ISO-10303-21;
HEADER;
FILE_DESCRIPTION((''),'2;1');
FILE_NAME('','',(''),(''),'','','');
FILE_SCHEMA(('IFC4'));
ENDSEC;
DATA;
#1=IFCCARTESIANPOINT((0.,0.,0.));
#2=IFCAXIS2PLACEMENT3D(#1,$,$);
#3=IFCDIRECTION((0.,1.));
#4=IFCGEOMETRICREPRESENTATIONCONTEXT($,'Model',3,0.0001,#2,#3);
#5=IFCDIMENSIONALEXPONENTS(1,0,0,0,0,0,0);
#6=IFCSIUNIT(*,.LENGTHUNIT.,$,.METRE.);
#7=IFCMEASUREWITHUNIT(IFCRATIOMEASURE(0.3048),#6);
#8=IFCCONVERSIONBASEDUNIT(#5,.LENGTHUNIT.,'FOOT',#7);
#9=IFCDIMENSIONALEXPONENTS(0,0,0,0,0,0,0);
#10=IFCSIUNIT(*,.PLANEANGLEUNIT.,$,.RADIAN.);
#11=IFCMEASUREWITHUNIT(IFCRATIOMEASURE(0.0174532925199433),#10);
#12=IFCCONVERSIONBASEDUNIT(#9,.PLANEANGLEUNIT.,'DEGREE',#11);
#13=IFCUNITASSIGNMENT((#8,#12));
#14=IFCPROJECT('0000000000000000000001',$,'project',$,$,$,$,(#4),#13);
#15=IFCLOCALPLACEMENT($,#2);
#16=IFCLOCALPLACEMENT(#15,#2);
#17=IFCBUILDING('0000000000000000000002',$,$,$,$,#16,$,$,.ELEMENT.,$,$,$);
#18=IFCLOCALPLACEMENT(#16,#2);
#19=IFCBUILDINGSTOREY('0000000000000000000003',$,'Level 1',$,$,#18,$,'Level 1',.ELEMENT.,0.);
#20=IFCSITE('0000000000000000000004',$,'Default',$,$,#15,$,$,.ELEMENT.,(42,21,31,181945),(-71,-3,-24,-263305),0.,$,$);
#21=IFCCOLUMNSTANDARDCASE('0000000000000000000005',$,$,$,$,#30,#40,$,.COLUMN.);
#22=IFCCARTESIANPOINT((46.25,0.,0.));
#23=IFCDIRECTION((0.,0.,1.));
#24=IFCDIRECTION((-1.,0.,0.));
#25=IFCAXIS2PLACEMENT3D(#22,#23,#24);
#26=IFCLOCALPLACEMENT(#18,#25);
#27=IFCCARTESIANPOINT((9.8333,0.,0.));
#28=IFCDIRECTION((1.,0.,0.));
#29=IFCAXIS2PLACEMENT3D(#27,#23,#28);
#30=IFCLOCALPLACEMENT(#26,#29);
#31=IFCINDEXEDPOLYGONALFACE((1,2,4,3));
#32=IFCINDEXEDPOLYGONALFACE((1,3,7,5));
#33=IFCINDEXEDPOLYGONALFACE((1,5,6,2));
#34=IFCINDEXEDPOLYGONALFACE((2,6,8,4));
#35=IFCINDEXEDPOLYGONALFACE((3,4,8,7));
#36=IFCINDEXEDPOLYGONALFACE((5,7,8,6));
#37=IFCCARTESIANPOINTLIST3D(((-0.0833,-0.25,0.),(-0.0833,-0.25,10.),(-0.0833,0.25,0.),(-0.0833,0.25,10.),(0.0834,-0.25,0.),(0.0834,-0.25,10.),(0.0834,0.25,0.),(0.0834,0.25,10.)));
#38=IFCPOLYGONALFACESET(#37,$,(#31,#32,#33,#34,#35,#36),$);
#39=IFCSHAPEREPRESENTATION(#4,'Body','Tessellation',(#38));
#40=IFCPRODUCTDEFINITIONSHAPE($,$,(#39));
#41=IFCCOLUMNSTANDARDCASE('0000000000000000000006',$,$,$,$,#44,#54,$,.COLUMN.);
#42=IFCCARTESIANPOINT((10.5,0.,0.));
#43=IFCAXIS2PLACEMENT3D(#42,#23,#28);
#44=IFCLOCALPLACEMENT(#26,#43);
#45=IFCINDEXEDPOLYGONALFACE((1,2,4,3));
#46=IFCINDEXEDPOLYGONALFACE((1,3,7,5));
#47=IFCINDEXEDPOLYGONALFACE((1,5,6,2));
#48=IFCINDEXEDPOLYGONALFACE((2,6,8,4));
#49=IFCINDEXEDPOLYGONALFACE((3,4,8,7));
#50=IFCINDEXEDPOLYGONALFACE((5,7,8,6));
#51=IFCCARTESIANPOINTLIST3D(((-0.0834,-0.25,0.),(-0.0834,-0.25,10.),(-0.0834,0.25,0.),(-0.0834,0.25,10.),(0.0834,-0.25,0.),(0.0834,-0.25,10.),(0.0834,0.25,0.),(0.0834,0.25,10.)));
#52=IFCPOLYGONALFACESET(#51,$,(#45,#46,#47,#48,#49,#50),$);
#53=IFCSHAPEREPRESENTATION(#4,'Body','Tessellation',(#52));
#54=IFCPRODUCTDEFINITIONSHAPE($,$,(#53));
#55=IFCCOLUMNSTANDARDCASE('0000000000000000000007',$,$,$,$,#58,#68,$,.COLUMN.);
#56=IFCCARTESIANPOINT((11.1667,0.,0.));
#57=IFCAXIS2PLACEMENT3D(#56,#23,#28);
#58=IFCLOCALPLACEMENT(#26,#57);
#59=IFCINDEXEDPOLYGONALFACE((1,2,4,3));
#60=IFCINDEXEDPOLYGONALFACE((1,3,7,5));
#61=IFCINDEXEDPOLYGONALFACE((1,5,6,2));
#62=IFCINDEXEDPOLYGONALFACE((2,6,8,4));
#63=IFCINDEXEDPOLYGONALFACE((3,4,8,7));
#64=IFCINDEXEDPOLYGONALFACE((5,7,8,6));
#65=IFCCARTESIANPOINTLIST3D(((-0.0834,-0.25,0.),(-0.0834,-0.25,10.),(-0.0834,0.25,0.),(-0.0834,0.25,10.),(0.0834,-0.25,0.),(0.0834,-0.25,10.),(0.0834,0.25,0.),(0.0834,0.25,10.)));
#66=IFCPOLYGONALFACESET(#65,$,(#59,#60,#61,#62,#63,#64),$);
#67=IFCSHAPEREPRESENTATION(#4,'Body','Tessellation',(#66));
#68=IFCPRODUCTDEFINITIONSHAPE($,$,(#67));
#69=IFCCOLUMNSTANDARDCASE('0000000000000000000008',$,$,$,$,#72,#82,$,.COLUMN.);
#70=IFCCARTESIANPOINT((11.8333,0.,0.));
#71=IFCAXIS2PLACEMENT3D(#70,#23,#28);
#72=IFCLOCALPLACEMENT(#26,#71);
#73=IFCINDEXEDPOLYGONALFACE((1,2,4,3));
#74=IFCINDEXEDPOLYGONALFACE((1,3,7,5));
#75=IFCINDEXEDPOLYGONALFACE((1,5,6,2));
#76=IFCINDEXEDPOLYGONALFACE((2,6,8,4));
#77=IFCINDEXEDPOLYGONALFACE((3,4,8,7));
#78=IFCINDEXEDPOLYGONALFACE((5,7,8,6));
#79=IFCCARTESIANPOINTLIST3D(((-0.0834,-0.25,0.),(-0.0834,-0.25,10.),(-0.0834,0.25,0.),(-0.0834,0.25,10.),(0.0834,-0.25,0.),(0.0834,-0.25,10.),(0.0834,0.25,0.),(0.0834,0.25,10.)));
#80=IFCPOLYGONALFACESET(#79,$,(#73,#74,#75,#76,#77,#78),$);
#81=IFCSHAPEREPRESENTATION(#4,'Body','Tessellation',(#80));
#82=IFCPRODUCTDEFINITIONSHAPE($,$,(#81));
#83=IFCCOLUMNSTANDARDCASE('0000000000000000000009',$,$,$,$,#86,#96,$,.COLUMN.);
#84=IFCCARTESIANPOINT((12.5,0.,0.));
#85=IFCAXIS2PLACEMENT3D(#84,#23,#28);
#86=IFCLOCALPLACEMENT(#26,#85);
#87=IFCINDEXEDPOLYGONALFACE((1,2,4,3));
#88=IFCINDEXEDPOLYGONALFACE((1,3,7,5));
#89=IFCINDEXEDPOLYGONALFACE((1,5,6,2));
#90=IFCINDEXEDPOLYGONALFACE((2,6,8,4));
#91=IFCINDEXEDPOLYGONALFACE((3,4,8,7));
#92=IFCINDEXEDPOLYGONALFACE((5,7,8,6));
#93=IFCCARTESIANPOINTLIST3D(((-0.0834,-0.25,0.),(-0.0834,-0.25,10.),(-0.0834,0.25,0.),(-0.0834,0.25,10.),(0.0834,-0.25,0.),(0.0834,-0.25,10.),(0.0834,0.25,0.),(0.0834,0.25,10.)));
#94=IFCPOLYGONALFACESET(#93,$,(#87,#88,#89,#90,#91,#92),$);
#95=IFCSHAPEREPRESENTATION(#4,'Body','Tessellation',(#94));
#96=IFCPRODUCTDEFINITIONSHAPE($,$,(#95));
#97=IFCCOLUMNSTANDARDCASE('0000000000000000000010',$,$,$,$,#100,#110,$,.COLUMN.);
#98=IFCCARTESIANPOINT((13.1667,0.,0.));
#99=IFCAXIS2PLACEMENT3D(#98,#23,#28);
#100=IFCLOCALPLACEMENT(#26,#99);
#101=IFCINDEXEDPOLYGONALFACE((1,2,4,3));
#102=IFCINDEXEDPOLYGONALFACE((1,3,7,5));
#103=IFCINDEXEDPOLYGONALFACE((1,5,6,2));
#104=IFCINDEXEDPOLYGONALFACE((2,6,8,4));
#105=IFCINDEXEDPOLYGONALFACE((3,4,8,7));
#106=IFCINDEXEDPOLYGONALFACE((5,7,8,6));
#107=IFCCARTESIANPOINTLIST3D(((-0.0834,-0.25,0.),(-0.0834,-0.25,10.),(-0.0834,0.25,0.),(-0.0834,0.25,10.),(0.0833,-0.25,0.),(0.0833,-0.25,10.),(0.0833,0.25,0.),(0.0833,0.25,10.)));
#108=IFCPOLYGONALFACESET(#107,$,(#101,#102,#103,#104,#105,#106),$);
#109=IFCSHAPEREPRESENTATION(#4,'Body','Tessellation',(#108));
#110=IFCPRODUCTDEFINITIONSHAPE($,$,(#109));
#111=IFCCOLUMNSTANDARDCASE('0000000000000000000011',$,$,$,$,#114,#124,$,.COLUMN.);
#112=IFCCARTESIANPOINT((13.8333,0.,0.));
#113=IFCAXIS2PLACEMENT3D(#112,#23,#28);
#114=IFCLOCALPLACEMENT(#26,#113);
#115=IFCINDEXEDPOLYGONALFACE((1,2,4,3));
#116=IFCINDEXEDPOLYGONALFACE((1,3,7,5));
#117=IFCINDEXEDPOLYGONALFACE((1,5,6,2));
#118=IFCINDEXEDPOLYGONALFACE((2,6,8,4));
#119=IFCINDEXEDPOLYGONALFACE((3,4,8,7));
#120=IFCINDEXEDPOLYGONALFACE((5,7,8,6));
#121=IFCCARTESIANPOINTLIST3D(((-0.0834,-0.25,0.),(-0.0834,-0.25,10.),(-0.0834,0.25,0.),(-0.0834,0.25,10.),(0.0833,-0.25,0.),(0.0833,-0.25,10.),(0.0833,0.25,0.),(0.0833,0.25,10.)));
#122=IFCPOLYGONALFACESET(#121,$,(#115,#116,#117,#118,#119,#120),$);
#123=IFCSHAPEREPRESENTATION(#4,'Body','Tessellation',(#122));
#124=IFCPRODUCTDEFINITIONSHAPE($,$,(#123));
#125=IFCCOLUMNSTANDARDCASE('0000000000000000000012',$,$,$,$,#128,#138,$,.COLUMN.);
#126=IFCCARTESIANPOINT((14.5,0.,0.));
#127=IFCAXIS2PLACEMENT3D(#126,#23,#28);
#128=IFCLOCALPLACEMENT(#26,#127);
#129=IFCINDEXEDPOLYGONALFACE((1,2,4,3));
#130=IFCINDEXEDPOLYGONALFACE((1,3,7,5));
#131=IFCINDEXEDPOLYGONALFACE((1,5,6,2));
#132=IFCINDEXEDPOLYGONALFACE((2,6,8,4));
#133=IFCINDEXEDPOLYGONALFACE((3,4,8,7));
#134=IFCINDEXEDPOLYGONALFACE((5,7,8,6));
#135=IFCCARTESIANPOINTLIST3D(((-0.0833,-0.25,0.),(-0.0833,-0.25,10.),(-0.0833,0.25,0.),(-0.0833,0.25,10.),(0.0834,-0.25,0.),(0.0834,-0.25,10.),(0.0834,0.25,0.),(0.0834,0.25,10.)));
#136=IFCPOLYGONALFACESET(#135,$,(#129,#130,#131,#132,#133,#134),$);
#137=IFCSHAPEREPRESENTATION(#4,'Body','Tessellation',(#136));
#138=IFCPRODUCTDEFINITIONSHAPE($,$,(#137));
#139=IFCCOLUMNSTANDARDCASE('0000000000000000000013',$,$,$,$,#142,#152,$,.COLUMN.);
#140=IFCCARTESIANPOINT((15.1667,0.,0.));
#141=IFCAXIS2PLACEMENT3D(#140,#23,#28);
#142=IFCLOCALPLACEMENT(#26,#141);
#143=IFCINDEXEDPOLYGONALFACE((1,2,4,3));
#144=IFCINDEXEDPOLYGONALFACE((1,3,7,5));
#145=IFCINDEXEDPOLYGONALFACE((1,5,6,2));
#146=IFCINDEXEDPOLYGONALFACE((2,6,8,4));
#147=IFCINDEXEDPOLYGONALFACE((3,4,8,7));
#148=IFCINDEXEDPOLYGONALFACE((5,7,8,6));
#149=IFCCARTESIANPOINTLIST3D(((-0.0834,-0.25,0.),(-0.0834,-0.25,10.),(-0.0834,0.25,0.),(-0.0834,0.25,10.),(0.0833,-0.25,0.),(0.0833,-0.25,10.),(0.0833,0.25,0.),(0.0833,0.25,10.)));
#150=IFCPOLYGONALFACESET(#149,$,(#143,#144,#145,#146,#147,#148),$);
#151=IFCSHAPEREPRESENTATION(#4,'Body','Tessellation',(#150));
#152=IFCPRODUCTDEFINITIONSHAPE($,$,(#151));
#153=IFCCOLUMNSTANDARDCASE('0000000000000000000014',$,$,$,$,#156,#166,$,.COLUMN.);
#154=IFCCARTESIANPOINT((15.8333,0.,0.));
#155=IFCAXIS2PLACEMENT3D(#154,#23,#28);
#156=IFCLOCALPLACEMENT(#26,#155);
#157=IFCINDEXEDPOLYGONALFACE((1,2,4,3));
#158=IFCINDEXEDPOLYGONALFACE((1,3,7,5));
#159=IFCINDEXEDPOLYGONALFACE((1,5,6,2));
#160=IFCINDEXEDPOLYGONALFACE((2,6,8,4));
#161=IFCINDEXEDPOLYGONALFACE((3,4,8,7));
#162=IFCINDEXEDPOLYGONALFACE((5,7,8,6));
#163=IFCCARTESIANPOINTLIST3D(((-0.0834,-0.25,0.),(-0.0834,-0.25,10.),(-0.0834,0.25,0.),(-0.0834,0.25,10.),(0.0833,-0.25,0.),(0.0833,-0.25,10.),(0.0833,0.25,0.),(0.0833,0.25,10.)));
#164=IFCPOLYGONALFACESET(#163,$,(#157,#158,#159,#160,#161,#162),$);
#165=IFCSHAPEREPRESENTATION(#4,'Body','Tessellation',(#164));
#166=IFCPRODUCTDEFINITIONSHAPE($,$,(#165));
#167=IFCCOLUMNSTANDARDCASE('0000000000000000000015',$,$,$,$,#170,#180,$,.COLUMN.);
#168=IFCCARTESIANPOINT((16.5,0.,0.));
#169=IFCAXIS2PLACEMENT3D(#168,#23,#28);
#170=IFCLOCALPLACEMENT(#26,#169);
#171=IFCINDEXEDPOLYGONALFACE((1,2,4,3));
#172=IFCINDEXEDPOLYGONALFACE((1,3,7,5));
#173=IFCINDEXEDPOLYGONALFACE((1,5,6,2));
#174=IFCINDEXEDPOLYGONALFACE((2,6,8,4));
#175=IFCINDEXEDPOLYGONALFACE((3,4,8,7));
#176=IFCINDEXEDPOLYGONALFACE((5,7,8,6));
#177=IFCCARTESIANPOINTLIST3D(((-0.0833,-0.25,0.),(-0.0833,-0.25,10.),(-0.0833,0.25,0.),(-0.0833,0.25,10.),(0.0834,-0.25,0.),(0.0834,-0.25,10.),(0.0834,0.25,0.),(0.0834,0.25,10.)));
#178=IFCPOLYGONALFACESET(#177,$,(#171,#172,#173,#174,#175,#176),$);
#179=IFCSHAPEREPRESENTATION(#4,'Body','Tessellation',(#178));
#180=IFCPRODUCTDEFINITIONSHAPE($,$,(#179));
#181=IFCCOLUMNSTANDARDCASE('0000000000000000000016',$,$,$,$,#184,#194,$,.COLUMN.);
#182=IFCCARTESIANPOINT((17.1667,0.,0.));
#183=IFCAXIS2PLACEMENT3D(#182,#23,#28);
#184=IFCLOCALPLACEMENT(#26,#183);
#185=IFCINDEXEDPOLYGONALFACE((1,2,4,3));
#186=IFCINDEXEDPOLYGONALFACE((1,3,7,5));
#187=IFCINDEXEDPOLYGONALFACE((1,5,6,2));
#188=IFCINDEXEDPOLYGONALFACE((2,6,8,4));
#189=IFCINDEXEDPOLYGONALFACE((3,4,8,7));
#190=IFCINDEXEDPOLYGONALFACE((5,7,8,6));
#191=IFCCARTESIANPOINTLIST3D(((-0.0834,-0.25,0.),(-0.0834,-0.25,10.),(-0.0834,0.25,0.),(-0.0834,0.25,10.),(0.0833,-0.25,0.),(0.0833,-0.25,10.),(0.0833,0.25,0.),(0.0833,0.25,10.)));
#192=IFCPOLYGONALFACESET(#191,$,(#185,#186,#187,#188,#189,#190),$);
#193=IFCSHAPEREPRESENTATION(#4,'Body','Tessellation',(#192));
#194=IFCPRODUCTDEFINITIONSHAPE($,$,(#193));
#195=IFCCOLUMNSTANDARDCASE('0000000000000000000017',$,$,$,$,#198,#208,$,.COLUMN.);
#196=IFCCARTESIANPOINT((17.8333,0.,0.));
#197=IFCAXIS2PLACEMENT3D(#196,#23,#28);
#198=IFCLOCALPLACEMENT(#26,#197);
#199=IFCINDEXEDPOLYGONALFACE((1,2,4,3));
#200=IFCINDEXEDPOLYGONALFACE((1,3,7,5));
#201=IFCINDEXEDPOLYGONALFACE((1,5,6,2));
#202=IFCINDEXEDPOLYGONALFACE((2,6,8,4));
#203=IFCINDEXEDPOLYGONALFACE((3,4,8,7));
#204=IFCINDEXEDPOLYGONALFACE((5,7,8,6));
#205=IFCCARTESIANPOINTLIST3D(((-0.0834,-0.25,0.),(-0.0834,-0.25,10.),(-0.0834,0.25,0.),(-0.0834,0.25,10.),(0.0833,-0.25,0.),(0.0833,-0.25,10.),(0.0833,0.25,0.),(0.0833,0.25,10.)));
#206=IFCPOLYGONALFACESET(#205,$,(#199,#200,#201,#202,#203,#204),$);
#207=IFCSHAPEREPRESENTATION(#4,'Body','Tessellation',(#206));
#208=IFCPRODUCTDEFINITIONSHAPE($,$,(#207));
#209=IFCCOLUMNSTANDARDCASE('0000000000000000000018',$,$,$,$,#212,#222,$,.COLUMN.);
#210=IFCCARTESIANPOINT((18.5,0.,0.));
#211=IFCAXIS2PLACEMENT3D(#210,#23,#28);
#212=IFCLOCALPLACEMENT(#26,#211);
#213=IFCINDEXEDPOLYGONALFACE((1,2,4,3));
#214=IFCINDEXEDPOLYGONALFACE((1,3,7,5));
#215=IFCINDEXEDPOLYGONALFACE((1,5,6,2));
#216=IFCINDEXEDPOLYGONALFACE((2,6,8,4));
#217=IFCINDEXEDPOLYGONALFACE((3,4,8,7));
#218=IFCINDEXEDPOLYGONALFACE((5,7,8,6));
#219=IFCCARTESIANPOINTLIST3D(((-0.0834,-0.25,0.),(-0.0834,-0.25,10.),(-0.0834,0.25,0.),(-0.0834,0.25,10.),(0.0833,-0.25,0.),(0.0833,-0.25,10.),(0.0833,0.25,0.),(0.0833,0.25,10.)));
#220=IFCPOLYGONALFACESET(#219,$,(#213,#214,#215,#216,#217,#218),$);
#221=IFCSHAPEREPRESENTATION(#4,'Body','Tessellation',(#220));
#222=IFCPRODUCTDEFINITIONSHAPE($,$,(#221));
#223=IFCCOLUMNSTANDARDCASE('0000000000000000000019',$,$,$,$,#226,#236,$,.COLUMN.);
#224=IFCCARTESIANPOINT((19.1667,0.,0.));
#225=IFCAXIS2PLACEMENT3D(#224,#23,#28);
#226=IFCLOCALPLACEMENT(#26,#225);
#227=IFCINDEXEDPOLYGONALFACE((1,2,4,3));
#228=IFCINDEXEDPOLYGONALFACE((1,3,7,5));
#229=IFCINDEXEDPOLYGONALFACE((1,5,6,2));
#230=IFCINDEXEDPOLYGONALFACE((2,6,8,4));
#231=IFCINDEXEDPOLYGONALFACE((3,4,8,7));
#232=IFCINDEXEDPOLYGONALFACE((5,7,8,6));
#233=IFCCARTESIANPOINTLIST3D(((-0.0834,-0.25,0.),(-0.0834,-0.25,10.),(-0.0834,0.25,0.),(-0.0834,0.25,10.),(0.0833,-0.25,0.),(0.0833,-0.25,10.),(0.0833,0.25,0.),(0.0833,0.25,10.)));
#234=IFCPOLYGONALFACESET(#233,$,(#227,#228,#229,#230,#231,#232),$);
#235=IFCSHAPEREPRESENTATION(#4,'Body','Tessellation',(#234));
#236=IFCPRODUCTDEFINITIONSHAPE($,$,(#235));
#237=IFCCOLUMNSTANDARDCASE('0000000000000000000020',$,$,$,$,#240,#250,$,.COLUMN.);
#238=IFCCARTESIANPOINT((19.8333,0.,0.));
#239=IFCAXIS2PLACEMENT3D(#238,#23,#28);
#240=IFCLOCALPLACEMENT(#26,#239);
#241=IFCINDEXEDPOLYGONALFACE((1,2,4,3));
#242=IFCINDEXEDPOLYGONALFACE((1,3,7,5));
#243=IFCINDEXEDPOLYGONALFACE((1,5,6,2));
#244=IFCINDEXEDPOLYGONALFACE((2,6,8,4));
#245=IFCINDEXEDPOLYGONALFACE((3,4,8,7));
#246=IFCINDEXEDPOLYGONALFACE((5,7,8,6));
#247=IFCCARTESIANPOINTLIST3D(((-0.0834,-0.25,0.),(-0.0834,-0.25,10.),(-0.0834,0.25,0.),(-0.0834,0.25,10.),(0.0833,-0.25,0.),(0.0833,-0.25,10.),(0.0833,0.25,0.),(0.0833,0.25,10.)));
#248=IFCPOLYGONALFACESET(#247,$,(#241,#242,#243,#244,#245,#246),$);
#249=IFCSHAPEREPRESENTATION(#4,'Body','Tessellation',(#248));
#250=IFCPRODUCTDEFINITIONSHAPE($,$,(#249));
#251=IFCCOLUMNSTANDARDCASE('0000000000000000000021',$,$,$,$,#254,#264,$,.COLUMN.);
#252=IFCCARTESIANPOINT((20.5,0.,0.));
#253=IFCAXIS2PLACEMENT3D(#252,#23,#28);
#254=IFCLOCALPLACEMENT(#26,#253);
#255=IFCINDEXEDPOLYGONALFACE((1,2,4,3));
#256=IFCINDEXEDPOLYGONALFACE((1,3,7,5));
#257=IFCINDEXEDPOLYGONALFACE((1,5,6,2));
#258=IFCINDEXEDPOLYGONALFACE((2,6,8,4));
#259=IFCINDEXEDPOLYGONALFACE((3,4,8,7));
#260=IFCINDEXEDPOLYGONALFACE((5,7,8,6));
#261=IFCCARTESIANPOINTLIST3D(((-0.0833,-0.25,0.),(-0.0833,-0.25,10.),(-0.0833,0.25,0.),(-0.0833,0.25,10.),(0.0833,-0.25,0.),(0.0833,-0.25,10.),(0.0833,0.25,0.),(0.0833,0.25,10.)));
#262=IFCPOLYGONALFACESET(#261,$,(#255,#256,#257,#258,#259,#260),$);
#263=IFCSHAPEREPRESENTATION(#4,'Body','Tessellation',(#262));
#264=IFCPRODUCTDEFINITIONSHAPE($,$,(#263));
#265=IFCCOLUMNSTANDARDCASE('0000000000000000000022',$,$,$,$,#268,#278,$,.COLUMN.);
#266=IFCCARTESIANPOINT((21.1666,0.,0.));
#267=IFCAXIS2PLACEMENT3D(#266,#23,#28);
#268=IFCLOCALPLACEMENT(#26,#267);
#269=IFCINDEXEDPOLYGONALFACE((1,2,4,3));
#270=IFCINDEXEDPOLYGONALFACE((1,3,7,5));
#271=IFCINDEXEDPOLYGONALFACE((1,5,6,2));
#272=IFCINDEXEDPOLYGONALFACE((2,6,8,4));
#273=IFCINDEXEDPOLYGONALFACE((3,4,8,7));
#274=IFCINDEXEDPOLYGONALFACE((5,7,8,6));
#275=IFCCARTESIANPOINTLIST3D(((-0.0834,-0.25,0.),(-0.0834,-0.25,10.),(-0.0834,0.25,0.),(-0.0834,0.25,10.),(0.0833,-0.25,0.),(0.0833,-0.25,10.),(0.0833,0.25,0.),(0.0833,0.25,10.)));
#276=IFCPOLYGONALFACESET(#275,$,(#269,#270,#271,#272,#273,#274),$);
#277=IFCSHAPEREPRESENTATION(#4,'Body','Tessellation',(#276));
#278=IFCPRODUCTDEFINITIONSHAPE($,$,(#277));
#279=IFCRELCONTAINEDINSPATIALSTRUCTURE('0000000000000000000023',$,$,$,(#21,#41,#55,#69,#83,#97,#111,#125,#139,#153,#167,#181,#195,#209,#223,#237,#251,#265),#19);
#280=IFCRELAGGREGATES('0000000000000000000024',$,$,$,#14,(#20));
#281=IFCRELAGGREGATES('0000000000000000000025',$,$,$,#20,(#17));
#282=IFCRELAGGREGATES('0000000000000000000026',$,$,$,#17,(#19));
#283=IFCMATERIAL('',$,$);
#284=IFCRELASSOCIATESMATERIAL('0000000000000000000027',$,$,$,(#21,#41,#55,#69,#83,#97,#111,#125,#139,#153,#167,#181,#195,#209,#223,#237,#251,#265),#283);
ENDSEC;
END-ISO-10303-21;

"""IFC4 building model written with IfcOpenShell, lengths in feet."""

from ifc_helpers import new_model, entity, si_unit, converted_unit, direction, frame, origin, place, context, project, spatial, rectangle, extrude, material, element, save


model = new_model("IFC4")

# Units and contexts
model_context = context("Model", 3, precision=0.0001, world=origin(), true_north=direction((0.0, 1.0)))
ifc_project = project(units=[converted_unit("LENGTHUNIT", "FOOT", entity("IfcRatioMeasure", 0.3048), si_unit("LENGTHUNIT", "METRE"), dimensions=[1, 0, 0, 0, 0, 0, 0]), converted_unit("PLANEANGLEUNIT", "DEGREE", entity("IfcRatioMeasure", 0.0174532925199433), si_unit("PLANEANGLEUNIT", "RADIAN"), dimensions=[0, 0, 0, 0, 0, 0, 0])], contexts=[model_context])

# Site, building, storey
site_placement = place(None, origin())
site = spatial("IfcSite", under=ifc_project, at=site_placement, Name="Default", CompositionType="ELEMENT", RefLatitude=(42, 21, 31, 181945), RefLongitude=(-71, -3, -24, -263305), RefElevation=0.0)
building_placement = place(site_placement, origin())
building = spatial("IfcBuilding", under=site, at=building_placement, CompositionType="ELEMENT")
storey_placement = place(building_placement, origin())
storey = spatial("IfcBuildingStorey", under=building, at=storey_placement, Name="Level 1", LongName="Level 1", CompositionType="ELEMENT", Elevation=0.0)

# Columns
ifc_material_1 = material(Name="")
placement = place(storey_placement, frame((46.25, 0.0, 0.0), z_axis=(0.0, 0.0, 1.0), x_axis=(-1.0, 0.0, 0.0)))
for number, where, z_axis, x_axis in (
    (1, (9.8333, 0.0, 0.0), (0.0, 0.0, 1.0), (1.0, 0.0, 0.0)),
    (2, (10.5, 0.0, 0.0), (0.0, 0.0, 1.0), (1.0, 0.0, 0.0)),
    (3, (11.1667, 0.0, 0.0), (0.0, 0.0, 1.0), (1.0, 0.0, 0.0)),
    (4, (11.8333, 0.0, 0.0), (0.0, 0.0, 1.0), (1.0, 0.0, 0.0)),
    (5, (12.5, 0.0, 0.0), (0.0, 0.0, 1.0), (1.0, 0.0, 0.0)),
    (6, (13.1667, 0.0, 0.0), (0.0, 0.0, 1.0), (1.0, 0.0, 0.0)),
    (7, (13.8333, 0.0, 0.0), (0.0, 0.0, 1.0), (1.0, 0.0, 0.0)),
    (8, (14.5, 0.0, 0.0), (0.0, 0.0, 1.0), (1.0, 0.0, 0.0)),
    (9, (15.1667, 0.0, 0.0), (0.0, 0.0, 1.0), (1.0, 0.0, 0.0)),
    (10, (15.8333, 0.0, 0.0), (0.0, 0.0, 1.0), (1.0, 0.0, 0.0)),
    (11, (16.5, 0.0, 0.0), (0.0, 0.0, 1.0), (1.0, 0.0, 0.0)),
    (12, (17.1667, 0.0, 0.0), (0.0, 0.0, 1.0), (1.0, 0.0, 0.0)),
    (13, (17.8333, 0.0, 0.0), (0.0, 0.0, 1.0), (1.0, 0.0, 0.0)),
    (14, (18.5, 0.0, 0.0), (0.0, 0.0, 1.0), (1.0, 0.0, 0.0)),
    (15, (19.1667, 0.0, 0.0), (0.0, 0.0, 1.0), (1.0, 0.0, 0.0)),
    (16, (19.8333, 0.0, 0.0), (0.0, 0.0, 1.0), (1.0, 0.0, 0.0)),
    (17, (20.5, 0.0, 0.0), (0.0, 0.0, 1.0), (1.0, 0.0, 0.0)),
    (18, (21.1666, 0.0, 0.0), (0.0, 0.0, 1.0), (1.0, 0.0, 0.0)),
):
    element("IfcColumnStandardCase", number, at=place(placement, frame(where, z_axis=z_axis, x_axis=x_axis)), inside=storey, material=ifc_material_1, PredefinedType="COLUMN", context=model_context, shape_type="SweptSolid", body=[
        extrude(rectangle(XDim=0.1667, YDim=0.5), origin(), (0.0, 0.0, 1.0), 10.0),
    ])

save(model, "model.ifc")
